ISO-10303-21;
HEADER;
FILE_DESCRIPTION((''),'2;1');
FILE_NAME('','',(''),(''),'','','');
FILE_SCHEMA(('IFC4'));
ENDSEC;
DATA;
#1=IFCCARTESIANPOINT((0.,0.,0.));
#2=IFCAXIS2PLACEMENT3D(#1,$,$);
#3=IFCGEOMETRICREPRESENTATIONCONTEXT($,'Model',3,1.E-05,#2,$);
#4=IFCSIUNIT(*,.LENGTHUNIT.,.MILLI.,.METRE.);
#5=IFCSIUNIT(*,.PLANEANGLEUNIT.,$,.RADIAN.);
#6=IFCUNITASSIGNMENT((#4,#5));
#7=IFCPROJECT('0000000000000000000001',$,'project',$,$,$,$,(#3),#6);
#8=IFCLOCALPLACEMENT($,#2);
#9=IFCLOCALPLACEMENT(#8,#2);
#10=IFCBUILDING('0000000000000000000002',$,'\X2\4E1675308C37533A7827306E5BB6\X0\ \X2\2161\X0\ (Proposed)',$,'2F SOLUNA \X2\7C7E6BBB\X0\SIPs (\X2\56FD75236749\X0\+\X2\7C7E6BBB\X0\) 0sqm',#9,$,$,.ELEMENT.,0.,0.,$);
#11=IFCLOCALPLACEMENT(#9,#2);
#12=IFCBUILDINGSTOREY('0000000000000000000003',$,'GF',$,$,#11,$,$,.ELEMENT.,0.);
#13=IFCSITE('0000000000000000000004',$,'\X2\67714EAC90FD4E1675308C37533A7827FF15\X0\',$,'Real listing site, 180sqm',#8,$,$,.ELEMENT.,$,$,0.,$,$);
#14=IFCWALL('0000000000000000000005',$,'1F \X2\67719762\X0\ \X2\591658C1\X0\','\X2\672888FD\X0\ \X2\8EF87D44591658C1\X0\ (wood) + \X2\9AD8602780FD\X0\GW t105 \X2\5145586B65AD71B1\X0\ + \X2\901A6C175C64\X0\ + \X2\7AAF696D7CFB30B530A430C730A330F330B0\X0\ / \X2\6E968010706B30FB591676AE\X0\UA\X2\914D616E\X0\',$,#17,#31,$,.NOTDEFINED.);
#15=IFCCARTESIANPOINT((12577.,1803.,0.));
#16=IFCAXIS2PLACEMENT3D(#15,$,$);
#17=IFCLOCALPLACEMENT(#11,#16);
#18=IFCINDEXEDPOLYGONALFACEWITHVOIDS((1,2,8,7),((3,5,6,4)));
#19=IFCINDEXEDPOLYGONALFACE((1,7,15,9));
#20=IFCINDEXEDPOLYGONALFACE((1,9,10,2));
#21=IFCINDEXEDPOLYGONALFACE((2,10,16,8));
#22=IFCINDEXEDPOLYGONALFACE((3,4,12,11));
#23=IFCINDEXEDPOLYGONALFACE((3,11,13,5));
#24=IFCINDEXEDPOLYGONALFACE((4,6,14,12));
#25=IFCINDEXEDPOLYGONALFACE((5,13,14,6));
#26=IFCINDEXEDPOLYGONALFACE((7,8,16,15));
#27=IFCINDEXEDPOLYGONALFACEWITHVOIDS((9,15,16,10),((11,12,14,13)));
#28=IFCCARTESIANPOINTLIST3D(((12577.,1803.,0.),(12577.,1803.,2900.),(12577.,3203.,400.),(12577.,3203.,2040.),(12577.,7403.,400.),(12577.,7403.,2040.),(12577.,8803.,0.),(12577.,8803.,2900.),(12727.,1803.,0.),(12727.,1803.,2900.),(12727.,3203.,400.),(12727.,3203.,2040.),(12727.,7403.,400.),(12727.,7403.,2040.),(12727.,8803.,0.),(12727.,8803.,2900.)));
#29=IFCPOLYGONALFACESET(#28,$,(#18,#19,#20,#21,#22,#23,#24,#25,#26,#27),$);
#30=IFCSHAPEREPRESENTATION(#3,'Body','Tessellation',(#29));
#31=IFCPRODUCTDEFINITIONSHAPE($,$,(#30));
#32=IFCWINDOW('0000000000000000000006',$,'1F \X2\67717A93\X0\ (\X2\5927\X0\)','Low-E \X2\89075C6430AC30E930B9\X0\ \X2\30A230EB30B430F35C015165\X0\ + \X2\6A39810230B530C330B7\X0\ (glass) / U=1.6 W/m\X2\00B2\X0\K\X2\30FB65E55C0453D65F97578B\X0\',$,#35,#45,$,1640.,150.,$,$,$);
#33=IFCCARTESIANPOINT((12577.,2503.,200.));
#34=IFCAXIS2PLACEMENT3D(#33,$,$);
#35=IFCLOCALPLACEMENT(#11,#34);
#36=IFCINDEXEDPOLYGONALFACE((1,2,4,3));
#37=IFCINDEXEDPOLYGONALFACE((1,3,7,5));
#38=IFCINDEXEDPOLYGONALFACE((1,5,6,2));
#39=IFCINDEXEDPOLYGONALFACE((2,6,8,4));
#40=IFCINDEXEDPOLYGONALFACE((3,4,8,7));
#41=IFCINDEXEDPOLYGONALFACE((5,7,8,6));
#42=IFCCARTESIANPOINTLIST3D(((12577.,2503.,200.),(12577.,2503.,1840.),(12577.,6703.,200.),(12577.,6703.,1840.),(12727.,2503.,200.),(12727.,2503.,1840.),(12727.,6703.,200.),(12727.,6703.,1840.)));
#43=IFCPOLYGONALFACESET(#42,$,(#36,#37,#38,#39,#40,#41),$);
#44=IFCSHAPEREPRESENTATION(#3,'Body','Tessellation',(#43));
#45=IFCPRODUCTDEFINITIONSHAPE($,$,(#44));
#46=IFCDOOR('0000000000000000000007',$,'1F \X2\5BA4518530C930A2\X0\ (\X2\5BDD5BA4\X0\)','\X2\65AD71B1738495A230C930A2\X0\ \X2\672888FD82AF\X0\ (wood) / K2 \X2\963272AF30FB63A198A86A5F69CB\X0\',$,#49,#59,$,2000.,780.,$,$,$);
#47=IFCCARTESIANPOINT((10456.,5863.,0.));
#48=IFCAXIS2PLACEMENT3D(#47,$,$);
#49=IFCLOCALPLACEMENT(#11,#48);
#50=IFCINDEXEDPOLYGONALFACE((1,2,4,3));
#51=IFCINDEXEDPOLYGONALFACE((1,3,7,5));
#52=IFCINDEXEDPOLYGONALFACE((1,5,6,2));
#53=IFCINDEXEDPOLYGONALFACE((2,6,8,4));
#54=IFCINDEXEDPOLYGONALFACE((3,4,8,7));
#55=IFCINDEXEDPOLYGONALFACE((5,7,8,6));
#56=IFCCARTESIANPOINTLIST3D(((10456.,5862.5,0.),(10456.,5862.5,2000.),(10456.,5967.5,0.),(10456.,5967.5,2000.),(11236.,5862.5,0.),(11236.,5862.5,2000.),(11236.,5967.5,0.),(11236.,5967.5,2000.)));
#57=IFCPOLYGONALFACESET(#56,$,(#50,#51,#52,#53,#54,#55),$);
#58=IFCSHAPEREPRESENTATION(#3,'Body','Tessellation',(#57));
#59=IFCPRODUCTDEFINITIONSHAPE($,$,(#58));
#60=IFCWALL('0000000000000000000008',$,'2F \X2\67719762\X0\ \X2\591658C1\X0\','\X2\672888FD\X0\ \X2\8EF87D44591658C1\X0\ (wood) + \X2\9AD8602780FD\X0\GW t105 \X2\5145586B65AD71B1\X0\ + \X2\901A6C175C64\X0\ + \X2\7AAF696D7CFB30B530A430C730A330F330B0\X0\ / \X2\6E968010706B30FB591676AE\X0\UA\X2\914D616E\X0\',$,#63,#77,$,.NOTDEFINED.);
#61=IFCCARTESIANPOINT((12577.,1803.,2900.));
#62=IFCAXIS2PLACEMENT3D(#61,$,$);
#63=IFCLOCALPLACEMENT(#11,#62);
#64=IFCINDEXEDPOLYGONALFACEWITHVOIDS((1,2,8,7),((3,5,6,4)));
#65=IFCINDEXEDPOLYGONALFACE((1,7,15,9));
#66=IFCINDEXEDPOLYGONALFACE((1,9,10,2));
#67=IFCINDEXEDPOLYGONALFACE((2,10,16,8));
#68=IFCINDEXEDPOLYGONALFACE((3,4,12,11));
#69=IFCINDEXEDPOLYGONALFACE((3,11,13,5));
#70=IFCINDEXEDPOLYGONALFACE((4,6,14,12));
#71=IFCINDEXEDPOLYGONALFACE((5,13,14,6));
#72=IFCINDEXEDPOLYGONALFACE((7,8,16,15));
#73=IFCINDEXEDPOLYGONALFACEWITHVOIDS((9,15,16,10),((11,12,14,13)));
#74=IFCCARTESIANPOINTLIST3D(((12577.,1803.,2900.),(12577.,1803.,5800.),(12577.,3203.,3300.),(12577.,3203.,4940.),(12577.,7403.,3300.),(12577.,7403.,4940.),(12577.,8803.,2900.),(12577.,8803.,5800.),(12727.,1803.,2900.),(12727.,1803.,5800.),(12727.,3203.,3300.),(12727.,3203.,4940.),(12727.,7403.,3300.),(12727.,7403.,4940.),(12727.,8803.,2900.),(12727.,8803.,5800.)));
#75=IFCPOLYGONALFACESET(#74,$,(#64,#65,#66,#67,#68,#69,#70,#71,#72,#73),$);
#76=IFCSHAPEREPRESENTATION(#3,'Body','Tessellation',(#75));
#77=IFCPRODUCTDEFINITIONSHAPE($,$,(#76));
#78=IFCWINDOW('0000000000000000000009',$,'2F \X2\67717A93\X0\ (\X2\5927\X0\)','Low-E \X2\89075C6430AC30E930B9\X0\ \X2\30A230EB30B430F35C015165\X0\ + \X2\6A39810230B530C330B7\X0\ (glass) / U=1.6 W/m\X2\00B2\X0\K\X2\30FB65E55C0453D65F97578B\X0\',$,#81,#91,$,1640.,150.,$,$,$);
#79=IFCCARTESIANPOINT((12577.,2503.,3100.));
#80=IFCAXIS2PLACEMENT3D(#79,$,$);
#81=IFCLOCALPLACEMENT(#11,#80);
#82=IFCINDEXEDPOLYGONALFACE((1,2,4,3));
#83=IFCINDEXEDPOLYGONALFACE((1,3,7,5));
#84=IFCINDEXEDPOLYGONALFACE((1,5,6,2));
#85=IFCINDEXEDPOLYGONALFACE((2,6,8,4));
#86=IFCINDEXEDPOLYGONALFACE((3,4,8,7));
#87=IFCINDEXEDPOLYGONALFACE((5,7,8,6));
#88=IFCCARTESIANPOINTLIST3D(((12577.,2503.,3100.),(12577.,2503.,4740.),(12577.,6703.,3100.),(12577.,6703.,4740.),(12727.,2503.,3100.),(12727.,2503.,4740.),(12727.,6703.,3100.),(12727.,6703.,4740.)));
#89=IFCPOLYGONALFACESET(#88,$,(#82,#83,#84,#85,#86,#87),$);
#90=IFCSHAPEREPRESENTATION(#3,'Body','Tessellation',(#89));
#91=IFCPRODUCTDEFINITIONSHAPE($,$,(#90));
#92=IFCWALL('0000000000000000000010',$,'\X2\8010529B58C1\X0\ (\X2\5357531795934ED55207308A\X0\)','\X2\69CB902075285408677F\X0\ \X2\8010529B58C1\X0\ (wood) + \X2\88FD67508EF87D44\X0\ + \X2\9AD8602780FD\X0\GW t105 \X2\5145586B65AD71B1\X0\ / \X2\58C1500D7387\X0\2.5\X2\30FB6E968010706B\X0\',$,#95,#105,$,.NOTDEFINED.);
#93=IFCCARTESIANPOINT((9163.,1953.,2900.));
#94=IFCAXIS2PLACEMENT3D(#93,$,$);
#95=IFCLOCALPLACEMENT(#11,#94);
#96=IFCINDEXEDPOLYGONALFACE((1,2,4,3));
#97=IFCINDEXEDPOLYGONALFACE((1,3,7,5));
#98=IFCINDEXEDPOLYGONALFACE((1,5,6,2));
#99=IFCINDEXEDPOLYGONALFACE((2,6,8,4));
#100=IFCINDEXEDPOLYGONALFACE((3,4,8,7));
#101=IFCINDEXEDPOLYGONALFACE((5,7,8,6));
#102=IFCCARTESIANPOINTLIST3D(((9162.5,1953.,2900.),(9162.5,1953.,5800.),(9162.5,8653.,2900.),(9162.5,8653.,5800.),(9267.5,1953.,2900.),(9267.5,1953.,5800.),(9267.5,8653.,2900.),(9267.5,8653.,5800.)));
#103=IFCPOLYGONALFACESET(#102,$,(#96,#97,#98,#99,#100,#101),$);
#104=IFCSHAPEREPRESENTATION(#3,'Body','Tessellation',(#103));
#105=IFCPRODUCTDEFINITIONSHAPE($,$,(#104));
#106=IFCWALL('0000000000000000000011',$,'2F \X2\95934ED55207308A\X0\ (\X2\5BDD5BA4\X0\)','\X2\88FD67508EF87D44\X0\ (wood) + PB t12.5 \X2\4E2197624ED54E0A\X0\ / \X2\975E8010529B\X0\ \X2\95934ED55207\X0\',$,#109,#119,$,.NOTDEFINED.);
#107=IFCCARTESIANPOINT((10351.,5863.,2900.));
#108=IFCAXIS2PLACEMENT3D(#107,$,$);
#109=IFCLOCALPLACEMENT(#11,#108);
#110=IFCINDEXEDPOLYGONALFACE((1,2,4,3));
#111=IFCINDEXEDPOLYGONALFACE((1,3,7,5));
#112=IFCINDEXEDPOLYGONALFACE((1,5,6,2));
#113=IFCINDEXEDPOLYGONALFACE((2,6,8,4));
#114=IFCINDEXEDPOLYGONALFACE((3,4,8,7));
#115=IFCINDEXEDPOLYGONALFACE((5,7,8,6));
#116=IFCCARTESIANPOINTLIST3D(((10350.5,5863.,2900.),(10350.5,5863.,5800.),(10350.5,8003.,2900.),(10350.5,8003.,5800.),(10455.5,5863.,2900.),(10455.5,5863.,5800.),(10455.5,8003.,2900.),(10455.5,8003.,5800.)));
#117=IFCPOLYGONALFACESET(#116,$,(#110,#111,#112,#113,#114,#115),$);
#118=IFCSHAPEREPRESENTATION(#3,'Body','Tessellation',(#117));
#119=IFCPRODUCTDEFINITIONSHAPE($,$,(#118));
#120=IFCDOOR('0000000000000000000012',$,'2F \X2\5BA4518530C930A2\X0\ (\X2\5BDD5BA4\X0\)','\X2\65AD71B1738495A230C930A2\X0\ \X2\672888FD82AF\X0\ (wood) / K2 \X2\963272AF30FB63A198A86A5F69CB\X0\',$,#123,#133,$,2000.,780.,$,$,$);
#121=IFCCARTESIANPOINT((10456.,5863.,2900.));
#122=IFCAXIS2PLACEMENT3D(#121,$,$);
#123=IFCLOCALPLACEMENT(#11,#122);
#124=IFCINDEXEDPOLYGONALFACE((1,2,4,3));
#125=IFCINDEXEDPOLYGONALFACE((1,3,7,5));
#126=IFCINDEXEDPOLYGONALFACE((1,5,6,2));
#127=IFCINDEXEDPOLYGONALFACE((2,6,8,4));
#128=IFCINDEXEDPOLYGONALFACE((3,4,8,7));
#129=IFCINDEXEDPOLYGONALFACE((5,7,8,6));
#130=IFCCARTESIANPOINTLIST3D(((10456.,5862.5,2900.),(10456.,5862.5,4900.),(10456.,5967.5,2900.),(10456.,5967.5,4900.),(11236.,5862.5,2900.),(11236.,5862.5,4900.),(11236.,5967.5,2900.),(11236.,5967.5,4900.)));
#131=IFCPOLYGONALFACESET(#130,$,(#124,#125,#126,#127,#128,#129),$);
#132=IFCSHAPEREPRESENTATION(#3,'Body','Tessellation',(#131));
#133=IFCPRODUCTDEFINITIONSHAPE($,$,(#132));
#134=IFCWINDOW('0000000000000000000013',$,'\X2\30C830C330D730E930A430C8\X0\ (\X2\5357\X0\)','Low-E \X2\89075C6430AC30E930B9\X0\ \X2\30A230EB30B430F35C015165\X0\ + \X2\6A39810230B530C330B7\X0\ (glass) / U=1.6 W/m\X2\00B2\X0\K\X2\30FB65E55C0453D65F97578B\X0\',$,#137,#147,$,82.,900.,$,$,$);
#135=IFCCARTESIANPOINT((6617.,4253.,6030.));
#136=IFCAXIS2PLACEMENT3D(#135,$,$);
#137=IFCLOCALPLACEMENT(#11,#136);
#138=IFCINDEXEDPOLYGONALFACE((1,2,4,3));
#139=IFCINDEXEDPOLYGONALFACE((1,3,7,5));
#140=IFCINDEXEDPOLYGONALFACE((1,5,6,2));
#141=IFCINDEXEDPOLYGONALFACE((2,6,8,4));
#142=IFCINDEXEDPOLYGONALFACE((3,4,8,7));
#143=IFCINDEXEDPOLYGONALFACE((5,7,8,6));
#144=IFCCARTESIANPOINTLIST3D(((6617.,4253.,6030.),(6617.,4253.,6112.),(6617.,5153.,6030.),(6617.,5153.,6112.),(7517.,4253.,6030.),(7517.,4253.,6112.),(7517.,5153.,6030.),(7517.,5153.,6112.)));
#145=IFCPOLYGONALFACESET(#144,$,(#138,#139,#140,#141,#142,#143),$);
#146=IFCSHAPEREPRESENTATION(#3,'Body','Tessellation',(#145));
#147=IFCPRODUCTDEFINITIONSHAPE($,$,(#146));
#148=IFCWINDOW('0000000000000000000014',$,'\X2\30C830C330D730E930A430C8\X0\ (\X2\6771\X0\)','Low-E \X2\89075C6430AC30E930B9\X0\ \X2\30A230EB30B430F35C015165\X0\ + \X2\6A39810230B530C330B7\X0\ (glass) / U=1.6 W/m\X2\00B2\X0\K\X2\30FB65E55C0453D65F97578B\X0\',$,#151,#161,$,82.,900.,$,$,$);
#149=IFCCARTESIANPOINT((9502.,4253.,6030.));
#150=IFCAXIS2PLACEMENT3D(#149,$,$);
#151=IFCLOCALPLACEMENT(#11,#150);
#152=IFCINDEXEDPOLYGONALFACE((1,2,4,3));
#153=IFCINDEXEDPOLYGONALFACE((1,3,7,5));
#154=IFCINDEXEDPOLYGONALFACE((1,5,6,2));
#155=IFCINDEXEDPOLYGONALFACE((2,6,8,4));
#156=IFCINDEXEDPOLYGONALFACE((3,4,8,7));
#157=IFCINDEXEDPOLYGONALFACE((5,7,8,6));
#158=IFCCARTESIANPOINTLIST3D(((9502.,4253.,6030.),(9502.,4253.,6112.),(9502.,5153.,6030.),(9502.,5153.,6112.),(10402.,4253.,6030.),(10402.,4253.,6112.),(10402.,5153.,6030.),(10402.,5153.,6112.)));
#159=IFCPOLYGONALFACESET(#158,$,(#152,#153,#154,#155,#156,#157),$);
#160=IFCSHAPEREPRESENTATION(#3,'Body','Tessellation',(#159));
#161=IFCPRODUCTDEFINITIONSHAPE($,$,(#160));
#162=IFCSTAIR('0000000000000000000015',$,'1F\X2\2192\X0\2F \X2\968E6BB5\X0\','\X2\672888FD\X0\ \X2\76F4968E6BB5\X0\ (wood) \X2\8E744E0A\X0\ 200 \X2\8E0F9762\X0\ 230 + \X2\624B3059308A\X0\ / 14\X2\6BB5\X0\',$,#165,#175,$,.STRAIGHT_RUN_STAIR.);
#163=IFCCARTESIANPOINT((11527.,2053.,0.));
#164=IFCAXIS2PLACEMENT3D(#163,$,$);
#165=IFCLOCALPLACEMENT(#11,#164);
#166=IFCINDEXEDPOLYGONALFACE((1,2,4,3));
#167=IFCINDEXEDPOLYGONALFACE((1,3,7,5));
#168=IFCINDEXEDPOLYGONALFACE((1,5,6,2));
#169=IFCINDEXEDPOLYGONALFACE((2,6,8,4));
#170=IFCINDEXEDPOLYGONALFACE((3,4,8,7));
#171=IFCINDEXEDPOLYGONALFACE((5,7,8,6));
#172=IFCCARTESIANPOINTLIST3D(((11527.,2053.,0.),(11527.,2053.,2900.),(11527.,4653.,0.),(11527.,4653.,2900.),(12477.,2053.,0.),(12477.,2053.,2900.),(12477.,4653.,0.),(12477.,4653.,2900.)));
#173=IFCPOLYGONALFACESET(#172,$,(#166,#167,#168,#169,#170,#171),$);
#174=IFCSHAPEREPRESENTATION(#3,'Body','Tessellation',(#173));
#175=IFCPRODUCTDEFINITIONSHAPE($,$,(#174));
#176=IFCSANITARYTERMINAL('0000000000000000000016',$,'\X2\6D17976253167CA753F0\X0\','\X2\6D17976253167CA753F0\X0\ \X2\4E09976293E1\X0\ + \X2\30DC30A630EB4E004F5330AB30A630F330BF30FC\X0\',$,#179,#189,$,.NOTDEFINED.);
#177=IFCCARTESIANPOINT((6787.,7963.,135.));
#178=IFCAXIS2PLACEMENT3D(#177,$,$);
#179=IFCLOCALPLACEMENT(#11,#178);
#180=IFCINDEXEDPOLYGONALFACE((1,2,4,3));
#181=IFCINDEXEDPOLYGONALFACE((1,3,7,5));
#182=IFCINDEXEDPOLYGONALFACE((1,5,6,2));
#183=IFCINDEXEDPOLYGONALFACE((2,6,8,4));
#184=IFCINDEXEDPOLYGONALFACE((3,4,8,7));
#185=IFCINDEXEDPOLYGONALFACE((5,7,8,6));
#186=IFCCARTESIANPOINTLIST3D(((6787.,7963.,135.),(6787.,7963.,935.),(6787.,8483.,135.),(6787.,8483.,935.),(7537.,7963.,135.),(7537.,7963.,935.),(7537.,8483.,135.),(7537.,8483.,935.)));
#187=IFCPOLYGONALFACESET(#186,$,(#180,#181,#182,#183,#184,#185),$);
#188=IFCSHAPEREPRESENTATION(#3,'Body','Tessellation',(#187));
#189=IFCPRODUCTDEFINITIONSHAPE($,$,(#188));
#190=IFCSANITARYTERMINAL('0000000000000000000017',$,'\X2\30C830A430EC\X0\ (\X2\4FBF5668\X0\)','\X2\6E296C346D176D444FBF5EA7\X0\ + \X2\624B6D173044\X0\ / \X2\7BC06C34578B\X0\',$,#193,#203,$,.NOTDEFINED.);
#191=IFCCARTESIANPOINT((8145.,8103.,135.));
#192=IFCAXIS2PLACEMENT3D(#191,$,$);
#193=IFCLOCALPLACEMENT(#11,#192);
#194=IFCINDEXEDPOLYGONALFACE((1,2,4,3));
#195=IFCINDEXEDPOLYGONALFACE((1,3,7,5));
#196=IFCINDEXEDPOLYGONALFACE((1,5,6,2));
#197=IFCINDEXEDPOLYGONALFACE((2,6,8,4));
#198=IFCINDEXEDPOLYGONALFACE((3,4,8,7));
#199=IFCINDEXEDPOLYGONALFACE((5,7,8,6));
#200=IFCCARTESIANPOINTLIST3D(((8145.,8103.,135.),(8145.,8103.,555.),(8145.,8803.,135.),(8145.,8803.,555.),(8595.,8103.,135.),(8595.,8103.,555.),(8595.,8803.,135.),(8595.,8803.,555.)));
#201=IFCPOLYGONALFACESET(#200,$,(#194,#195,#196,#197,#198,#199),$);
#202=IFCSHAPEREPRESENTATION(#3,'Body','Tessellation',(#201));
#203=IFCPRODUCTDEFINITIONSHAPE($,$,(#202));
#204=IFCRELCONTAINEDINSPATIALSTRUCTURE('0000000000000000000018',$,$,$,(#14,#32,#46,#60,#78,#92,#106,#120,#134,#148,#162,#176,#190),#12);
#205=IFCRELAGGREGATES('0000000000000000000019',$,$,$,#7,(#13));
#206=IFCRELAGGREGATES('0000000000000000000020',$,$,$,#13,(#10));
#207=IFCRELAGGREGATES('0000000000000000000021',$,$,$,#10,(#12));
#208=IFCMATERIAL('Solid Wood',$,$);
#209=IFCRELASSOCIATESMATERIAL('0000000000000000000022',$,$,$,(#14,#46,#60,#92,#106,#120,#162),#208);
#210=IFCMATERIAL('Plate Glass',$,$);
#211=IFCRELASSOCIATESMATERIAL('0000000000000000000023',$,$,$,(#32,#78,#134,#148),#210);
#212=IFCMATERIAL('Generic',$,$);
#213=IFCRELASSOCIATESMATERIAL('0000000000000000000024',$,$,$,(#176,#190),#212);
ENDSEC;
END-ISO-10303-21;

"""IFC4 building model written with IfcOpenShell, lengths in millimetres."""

from ifc_helpers import new_model, si_unit, frame, frame_2d, origin, place, context, project, spatial, rectangle, extrude, material, element, fill, save


model = new_model("IFC4")

# Units and contexts
model_context = context("Model", 3, precision=1e-05, world=origin())
ifc_project = project(units=[si_unit("LENGTHUNIT", "METRE", prefix="MILLI"), si_unit("PLANEANGLEUNIT", "RADIAN")], contexts=[model_context])

# Site, building, storey
site_placement = place(None, origin())
site = spatial("IfcSite", under=ifc_project, at=site_placement, Name="東京都世田谷区砧５", ObjectType="Real listing site, 180sqm", CompositionType="ELEMENT", RefElevation=0.0)
building_placement = place(site_placement, origin())
building = spatial("IfcBuilding", under=site, at=building_placement, Name="世田谷区砧の家 Ⅱ (Proposed)", ObjectType="2F SOLUNA 籾殻SIPs (国産杉+籾殻) 0sqm", CompositionType="ELEMENT", ElevationOfRefHeight=0.0, ElevationOfTerrain=0.0)
storey_placement = place(building_placement, origin())
storey = spatial("IfcBuildingStorey", under=building, at=storey_placement, Name="GF", CompositionType="ELEMENT", Elevation=0.0)

# Wall, opening, window
ifc_material_1 = material(Name="Solid Wood")
wall_1_placement = place(storey_placement, frame((12577.0, 1803.0, 0.0)))
wall_1 = element("IfcWall", 1, at=wall_1_placement, inside=storey, material=ifc_material_1, Name="1F 東面 外壁", Description="木製 軸組外壁 (wood) + 高性能GW t105 充填断熱 + 通気層 + 窯業系サイディング / 準耐火・外皮UA配慮", PredefinedType="NOTDEFINED", context=model_context, shape_type="SweptSolid", body=[
    extrude(rectangle(XDim=150.0, YDim=7000.0, at=frame_2d((75.0, 3500.0))), frame((12577.0, 1803.0, 0.0)), (0.0, 0.0, 1.0), 2900.0),
])
opening_1_placement = place(storey_placement, frame((12577.0, 2503.0, 200.0)))
opening_1 = element("IfcOpeningElement", 2, at=opening_1_placement, cuts=wall_1, PredefinedType="NOTDEFINED", context=model_context, shape_type="SweptSolid", body=[
    extrude(rectangle(XDim=150.0, YDim=4200.0, at=frame_2d((75.0, 2100.0))), frame((12577.0, 2503.0, 200.0)), (0.0, 0.0, 1.0), 1640.0),
])
ifc_material_2 = material(Name="Plate Glass")
window_1_placement = place(storey_placement, frame((12577.0, 2503.0, 200.0)))
window_1 = element("IfcWindow", 3, at=window_1_placement, inside=storey, material=ifc_material_2, Name="1F 東窓 (大)", Description="Low-E 複層ガラス アルゴン封入 + 樹脂サッシ (glass) / U=1.6 W/m²K・日射取得型", OverallHeight=1640.0, OverallWidth=150.0, context=model_context, shape_type="SweptSolid", body=[
    extrude(rectangle(XDim=150.0, YDim=4200.0, at=frame_2d((75.0, 2100.0))), frame((12577.0, 2503.0, 200.0)), (0.0, 0.0, 1.0), 1640.0),
])
fill(opening_1, window_1)

# Door
door_1_placement = place(storey_placement, frame((10456.0, 5863.0, 0.0)))
element("IfcDoor", 4, at=door_1_placement, inside=storey, material=ifc_material_1, Name="1F 室内ドア (寝室)", Description="断熱玄関ドア 木製芯 (wood) / K2 防犯・採風機構", OverallHeight=2000.0, OverallWidth=780.0, context=model_context, shape_type="SweptSolid", body=[
    extrude(rectangle(XDim=780.0, YDim=105.0, at=frame_2d((390.0, 52.0))), frame((10456.0, 5863.0, 0.0)), (0.0, 0.0, 1.0), 2000.0),
])

# Wall, opening, window
wall_2_placement = place(storey_placement, frame((12577.0, 1803.0, 2900.0)))
wall_2 = element("IfcWall", 5, at=wall_2_placement, inside=storey, material=ifc_material_1, Name="2F 東面 外壁", Description="木製 軸組外壁 (wood) + 高性能GW t105 充填断熱 + 通気層 + 窯業系サイディング / 準耐火・外皮UA配慮", PredefinedType="NOTDEFINED", context=model_context, shape_type="SweptSolid", body=[
    extrude(rectangle(XDim=150.0, YDim=7000.0, at=frame_2d((75.0, 3500.0))), frame((12577.0, 1803.0, 2900.0)), (0.0, 0.0, 1.0), 2900.0),
])
opening_2_placement = place(storey_placement, frame((12577.0, 2503.0, 3100.0)))
opening_2 = element("IfcOpeningElement", 6, at=opening_2_placement, cuts=wall_2, PredefinedType="NOTDEFINED", context=model_context, shape_type="SweptSolid", body=[
    extrude(rectangle(XDim=150.0, YDim=4200.0, at=frame_2d((75.0, 2100.0))), frame((12577.0, 2503.0, 3100.0)), (0.0, 0.0, 1.0), 1640.0),
])
window_2_placement = place(storey_placement, frame((12577.0, 2503.0, 3100.0)))
window_2 = element("IfcWindow", 7, at=window_2_placement, inside=storey, material=ifc_material_2, Name="2F 東窓 (大)", Description="Low-E 複層ガラス アルゴン封入 + 樹脂サッシ (glass) / U=1.6 W/m²K・日射取得型", OverallHeight=1640.0, OverallWidth=150.0, context=model_context, shape_type="SweptSolid", body=[
    extrude(rectangle(XDim=150.0, YDim=4200.0, at=frame_2d((75.0, 2100.0))), frame((12577.0, 2503.0, 3100.0)), (0.0, 0.0, 1.0), 1640.0),
])
fill(opening_2, window_2)

# Walls
wall_3_placement = place(storey_placement, frame((9163.0, 1953.0, 2900.0)))
element("IfcWall", 8, at=wall_3_placement, inside=storey, material=ifc_material_1, Name="耐力壁 (南北間仕切り)", Description="構造用合板 耐力壁 (wood) + 製材軸組 + 高性能GW t105 充填断熱 / 壁倍率2.5・準耐火", PredefinedType="NOTDEFINED", context=model_context, shape_type="SweptSolid", body=[
    extrude(rectangle(XDim=105.0, YDim=6700.0, at=frame_2d((52.0, 3350.0))), frame((9163.0, 1953.0, 2900.0)), (0.0, 0.0, 1.0), 2900.0),
])
wall_4_placement = place(storey_placement, frame((10351.0, 5863.0, 2900.0)))
element("IfcWall", 9, at=wall_4_placement, inside=storey, material=ifc_material_1, Name="2F 間仕切り (寝室)", Description="製材軸組 (wood) + PB t12.5 両面仕上 / 非耐力 間仕切", PredefinedType="NOTDEFINED", context=model_context, shape_type="SweptSolid", body=[
    extrude(rectangle(XDim=105.0, YDim=2140.0, at=frame_2d((52.0, 1070.0))), frame((10351.0, 5863.0, 2900.0)), (0.0, 0.0, 1.0), 2900.0),
])

# Door
door_2_placement = place(storey_placement, frame((10456.0, 5863.0, 2900.0)))
element("IfcDoor", 10, at=door_2_placement, inside=storey, material=ifc_material_1, Name="2F 室内ドア (寝室)", Description="断熱玄関ドア 木製芯 (wood) / K2 防犯・採風機構", OverallHeight=2000.0, OverallWidth=780.0, context=model_context, shape_type="SweptSolid", body=[
    extrude(rectangle(XDim=780.0, YDim=105.0, at=frame_2d((390.0, 52.0))), frame((10456.0, 5863.0, 2900.0)), (0.0, 0.0, 1.0), 2000.0),
])

# Windows
window_3_placement = place(storey_placement, frame((6617.0, 4253.0, 6030.0)))
element("IfcWindow", 11, at=window_3_placement, inside=storey, material=ifc_material_2, Name="トップライト (南)", Description="Low-E 複層ガラス アルゴン封入 + 樹脂サッシ (glass) / U=1.6 W/m²K・日射取得型", OverallHeight=82.0, OverallWidth=900.0, context=model_context, shape_type="SweptSolid", body=[
    extrude(rectangle(XDim=900.0, YDim=900.0, at=frame_2d((450.0, 450.0))), frame((6617.0, 4253.0, 6030.0)), (0.0, 0.0, 1.0), 82.0),
])
window_4_placement = place(storey_placement, frame((9502.0, 4253.0, 6030.0)))
element("IfcWindow", 12, at=window_4_placement, inside=storey, material=ifc_material_2, Name="トップライト (東)", Description="Low-E 複層ガラス アルゴン封入 + 樹脂サッシ (glass) / U=1.6 W/m²K・日射取得型", OverallHeight=82.0, OverallWidth=900.0, context=model_context, shape_type="SweptSolid", body=[
    extrude(rectangle(XDim=900.0, YDim=900.0, at=frame_2d((450.0, 450.0))), frame((9502.0, 4253.0, 6030.0)), (0.0, 0.0, 1.0), 82.0),
])

# Stair
stair_placement = place(storey_placement, frame((11527.0, 2053.0, 0.0)))
element("IfcStair", 13, at=stair_placement, inside=storey, material=ifc_material_1, Name="1F→2F 階段", Description="木製 直階段 (wood) 蹴上 200 踏面 230 + 手すり / 14段", PredefinedType="STRAIGHT_RUN_STAIR", context=model_context, shape_type="SweptSolid", body=[
    extrude(rectangle(XDim=950.0, YDim=2600.0, at=frame_2d((475.0, 1300.0))), frame((11527.0, 2053.0, 0.0)), (0.0, 0.0, 1.0), 2900.0),
])

# Sanitary terminals
ifc_material_3 = material(Name="Generic")
sanitary_terminal_1_placement = place(storey_placement, frame((6787.0, 7963.0, 135.0)))
element("IfcSanitaryTerminal", 14, at=sanitary_terminal_1_placement, inside=storey, material=ifc_material_3, Name="洗面化粧台", Description="洗面化粧台 三面鏡 + ボウル一体カウンター", PredefinedType="NOTDEFINED", context=model_context, shape_type="SweptSolid", body=[
    extrude(rectangle(XDim=750.0, YDim=520.0, at=frame_2d((375.0, 260.0))), frame((6787.0, 7963.0, 135.0)), (0.0, 0.0, 1.0), 800.0),
])
sanitary_terminal_2_placement = place(storey_placement, frame((8145.0, 8103.0, 135.0)))
element("IfcSanitaryTerminal", 15, at=sanitary_terminal_2_placement, inside=storey, material=ifc_material_3, Name="トイレ (便器)", Description="温水洗浄便座 + 手洗い / 節水型", PredefinedType="NOTDEFINED", context=model_context, shape_type="SweptSolid", body=[
    extrude(rectangle(XDim=450.0, YDim=700.0, at=frame_2d((225.0, 350.0))), frame((8145.0, 8103.0, 135.0)), (0.0, 0.0, 1.0), 420.0),
])

save(model, "model.ifc")
